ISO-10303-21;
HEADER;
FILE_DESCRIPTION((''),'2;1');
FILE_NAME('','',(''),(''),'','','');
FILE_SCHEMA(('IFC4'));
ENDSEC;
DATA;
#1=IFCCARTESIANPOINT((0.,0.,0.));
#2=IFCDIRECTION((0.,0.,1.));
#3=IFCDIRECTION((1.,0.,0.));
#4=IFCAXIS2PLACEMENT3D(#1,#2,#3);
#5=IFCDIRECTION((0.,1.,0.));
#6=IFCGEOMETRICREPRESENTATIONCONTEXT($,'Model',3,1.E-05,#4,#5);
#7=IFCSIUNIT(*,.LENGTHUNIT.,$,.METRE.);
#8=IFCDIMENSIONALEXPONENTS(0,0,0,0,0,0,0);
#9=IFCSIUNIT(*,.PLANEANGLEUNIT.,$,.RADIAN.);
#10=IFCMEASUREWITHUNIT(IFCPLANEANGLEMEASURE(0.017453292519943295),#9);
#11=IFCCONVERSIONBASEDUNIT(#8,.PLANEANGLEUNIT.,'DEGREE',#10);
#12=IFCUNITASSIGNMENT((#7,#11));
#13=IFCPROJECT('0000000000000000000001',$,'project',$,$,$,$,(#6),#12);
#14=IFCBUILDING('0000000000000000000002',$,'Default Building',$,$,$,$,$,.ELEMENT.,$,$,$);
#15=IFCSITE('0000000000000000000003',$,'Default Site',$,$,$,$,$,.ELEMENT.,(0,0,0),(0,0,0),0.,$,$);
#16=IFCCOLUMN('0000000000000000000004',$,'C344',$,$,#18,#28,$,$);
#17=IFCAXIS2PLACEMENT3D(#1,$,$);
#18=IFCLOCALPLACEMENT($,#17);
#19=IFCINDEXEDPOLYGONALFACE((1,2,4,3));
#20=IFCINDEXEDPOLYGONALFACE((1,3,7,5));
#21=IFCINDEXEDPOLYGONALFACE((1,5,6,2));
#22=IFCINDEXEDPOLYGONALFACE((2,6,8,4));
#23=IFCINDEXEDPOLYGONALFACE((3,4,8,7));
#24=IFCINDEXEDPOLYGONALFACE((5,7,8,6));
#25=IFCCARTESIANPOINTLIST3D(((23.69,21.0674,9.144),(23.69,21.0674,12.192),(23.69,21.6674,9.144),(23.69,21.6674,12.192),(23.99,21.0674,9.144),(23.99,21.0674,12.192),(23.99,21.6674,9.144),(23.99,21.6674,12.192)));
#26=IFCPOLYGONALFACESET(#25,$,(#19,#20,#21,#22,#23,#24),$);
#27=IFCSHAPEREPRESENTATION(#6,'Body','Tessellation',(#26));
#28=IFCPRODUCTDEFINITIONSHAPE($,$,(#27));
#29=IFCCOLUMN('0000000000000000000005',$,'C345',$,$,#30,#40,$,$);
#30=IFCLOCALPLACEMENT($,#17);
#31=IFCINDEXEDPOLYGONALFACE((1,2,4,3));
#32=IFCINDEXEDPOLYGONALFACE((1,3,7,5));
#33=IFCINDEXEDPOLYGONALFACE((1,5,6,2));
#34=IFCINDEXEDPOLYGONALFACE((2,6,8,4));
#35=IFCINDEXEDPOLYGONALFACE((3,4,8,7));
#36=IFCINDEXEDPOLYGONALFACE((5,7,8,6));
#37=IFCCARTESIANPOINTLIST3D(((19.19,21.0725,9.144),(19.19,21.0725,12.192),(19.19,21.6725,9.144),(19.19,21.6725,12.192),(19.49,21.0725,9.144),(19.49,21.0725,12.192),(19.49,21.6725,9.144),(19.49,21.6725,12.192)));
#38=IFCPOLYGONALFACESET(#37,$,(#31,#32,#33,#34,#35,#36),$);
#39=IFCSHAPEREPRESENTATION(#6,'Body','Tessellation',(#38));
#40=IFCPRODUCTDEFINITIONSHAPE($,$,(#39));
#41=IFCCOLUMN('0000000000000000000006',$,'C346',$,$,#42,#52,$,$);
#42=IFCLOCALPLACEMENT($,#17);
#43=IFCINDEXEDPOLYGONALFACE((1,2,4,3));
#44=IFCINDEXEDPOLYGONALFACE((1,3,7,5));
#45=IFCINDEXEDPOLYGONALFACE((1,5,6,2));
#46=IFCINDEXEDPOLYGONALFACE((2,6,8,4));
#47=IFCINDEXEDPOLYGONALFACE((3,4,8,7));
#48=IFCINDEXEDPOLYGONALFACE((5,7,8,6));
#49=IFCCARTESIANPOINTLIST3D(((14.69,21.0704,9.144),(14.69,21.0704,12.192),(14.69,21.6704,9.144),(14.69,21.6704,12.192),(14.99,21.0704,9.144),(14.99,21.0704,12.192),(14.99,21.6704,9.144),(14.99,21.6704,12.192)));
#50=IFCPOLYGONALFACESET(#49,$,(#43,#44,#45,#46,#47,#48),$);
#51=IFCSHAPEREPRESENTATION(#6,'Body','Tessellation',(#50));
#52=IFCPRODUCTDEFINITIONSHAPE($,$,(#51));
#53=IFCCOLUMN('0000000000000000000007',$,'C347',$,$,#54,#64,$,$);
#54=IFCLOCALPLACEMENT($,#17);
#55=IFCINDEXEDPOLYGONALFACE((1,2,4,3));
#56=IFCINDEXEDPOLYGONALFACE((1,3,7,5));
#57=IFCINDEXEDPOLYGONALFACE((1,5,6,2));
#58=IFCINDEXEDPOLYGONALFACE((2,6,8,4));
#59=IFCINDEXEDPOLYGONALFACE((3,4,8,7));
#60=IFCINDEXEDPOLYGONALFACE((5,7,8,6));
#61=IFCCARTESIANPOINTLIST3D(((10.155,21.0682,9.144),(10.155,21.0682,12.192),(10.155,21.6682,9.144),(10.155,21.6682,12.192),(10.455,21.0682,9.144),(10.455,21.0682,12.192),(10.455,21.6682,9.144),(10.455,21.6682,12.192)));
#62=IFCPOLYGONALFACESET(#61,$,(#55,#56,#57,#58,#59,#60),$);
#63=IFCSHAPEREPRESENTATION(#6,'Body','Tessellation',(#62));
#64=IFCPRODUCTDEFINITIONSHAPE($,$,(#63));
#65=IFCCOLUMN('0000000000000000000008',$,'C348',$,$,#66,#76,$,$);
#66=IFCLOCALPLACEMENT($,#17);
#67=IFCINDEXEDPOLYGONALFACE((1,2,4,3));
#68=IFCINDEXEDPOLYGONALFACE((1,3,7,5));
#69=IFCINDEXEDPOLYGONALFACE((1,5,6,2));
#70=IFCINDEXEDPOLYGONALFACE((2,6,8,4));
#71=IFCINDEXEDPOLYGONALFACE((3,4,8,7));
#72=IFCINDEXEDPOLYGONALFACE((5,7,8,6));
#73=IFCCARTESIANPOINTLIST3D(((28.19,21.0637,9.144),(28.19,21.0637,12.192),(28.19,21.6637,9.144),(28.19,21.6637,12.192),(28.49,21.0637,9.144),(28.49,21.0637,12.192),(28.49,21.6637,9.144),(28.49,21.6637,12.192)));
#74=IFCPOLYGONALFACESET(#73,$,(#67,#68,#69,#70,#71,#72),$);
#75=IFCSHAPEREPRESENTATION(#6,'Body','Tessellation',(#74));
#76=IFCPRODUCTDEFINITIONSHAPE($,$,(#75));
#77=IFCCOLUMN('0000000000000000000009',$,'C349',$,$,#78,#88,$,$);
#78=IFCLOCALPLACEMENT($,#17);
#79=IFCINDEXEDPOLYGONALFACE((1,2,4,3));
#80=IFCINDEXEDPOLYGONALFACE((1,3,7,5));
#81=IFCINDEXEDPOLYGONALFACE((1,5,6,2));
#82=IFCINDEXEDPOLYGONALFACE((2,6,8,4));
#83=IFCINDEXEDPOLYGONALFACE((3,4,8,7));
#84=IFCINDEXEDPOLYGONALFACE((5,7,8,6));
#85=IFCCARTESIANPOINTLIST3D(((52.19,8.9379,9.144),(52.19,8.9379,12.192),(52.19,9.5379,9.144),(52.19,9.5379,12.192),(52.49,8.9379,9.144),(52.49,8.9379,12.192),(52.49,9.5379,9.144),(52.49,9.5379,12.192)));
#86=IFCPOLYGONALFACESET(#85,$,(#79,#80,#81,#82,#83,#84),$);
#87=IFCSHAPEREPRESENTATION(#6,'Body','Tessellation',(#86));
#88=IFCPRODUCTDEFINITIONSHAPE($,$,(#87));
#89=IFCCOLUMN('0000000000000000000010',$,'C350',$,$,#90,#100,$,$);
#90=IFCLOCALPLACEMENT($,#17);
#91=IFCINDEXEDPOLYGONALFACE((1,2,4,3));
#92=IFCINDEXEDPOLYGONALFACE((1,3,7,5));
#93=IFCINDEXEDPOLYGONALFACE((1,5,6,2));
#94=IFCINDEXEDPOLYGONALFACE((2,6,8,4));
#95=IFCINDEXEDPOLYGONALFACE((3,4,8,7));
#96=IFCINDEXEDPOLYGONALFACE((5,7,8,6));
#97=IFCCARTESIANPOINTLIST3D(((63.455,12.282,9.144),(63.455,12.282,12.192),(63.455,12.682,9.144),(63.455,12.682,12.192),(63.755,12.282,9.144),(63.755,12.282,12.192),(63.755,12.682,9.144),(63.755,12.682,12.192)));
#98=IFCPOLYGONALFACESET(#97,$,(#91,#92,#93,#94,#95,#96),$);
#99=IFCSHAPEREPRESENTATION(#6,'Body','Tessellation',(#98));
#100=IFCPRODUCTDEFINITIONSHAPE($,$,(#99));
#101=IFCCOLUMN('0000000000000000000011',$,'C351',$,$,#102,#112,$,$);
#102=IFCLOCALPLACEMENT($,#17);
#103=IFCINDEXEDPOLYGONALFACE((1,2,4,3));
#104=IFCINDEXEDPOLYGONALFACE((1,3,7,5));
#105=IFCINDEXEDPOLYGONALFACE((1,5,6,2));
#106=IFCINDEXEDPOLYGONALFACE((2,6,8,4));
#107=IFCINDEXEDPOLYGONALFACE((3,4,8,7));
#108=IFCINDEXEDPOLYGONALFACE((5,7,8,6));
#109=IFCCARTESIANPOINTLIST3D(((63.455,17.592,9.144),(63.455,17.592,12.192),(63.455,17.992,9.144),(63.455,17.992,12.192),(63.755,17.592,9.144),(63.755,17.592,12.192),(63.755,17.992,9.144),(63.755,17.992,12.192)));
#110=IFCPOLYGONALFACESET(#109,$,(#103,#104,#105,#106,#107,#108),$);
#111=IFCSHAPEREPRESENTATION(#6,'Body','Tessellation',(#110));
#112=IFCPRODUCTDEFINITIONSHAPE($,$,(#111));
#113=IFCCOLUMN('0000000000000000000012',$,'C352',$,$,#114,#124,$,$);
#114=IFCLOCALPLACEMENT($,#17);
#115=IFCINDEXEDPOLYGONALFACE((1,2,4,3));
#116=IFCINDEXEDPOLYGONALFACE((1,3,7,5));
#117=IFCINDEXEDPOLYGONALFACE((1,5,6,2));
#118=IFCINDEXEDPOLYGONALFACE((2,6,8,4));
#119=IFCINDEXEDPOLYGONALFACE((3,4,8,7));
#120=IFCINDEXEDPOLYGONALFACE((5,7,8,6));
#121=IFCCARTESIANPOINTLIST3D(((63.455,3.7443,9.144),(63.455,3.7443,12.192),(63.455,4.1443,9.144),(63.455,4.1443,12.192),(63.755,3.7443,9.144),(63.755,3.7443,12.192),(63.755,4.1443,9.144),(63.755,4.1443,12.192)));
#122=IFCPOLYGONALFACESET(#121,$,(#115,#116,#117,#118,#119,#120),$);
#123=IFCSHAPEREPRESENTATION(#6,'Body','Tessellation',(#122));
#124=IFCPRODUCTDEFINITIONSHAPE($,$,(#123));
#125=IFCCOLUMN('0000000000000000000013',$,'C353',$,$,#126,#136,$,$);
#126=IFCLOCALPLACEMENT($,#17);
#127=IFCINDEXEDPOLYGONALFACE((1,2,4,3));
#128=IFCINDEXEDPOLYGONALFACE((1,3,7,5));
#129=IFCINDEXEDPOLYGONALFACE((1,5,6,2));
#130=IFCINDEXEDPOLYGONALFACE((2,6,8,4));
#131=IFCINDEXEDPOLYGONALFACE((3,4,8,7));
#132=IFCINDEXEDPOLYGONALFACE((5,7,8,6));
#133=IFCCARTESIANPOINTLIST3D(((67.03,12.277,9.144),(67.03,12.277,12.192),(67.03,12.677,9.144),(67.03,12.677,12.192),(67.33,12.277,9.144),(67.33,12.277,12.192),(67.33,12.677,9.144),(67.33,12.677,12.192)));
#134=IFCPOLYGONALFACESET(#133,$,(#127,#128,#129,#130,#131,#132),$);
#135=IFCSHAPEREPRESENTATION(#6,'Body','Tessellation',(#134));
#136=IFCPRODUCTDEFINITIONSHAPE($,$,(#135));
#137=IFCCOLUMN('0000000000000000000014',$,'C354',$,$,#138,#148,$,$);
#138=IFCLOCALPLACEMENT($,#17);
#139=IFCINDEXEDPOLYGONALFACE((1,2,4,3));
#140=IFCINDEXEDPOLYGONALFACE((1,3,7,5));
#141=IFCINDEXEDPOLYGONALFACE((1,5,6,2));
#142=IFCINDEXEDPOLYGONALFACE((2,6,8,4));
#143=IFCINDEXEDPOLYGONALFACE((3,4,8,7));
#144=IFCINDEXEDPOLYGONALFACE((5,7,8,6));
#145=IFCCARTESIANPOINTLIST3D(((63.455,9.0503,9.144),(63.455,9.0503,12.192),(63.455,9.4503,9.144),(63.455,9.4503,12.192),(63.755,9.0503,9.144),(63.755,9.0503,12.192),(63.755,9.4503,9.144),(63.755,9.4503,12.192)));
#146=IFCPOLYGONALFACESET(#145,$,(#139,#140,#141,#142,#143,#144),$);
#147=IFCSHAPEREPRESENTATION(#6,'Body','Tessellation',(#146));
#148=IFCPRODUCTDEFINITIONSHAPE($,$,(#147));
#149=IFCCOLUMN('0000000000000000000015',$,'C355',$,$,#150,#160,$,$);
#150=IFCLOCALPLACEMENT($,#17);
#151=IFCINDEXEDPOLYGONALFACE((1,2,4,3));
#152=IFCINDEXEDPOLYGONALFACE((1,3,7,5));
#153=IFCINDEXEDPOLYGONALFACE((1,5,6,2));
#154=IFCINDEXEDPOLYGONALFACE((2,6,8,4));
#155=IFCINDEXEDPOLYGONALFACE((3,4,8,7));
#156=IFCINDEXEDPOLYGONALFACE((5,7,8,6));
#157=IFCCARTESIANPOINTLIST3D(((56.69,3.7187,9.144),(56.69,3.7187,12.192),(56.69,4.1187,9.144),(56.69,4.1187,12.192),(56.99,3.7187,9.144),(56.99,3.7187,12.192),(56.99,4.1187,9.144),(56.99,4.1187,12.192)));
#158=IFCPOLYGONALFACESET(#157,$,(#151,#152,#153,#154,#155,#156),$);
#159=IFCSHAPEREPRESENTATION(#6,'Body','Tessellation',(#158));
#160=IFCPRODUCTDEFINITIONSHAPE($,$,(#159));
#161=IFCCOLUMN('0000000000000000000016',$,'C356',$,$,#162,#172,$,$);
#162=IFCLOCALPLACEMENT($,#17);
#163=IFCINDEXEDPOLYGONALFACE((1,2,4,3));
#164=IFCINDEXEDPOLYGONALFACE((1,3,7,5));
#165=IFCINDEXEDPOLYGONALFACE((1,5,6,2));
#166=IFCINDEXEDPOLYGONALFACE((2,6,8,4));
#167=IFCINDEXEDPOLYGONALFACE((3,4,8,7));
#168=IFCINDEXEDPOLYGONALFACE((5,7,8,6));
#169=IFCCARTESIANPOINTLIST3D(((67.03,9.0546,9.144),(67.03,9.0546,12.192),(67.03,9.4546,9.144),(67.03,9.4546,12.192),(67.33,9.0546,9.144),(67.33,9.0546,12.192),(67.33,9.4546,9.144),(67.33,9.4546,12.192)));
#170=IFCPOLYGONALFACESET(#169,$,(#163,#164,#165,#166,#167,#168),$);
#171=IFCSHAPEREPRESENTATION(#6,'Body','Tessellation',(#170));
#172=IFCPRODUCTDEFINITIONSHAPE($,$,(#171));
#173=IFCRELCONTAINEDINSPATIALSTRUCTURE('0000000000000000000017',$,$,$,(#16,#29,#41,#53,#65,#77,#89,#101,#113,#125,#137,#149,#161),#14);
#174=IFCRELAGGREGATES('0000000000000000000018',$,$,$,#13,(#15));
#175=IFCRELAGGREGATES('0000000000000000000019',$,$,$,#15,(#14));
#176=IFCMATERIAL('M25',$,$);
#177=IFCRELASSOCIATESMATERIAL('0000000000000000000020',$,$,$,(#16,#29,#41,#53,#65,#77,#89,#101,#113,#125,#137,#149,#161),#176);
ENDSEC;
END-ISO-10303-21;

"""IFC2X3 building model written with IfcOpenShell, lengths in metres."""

from ifc_helpers import new_model, entity, si_unit, converted_unit, direction, frame, frame_2d, origin_with_axes, place, context, project, spatial, rectangle, extrude, material, element, save


model = new_model("IFC2X3")

# Units and contexts
model_context = context("Model", 3, precision=1e-05, world=origin_with_axes(), true_north=direction((0.0, 1.0, 0.0)))
ifc_project = project(units=[si_unit("LENGTHUNIT", "METRE"), converted_unit("PLANEANGLEUNIT", "DEGREE", entity("IfcPlaneAngleMeasure", 0.017453292519943295), si_unit("PLANEANGLEUNIT", "RADIAN"), dimensions=[0, 0, 0, 0, 0, 0, 0])], contexts=[model_context])

# Site, building
site = spatial("IfcSite", under=ifc_project, Name="Default Site", CompositionType="ELEMENT", RefLatitude=(0, 0, 0), RefLongitude=(0, 0, 0), RefElevation=0.0)
building = spatial("IfcBuilding", under=site, Name="Default Building", CompositionType="ELEMENT")

# Columns
ifc_material = material(Name="M25")
placement = place(None, origin_with_axes())
element("IfcColumn", 1, at=placement, inside=building, material=ifc_material, Name="C344", context=model_context, shape_type="SweptSolid", body=[
    extrude(rectangle(XDim=0.3, YDim=0.6, at=frame_2d((0.0, 0.0), x_axis=(1.0, 0.0, 0.0))), frame((23.84, 21.3674, 9.144), z_axis=(0.0, 0.0, 1.0), x_axis=(1.0, 0.0, 0.0)), (0.0, 0.0, 1.0), 3.048),
])
element("IfcColumn", 2, at=placement, inside=building, material=ifc_material, Name="C345", context=model_context, shape_type="SweptSolid", body=[
    extrude(rectangle(XDim=0.3, YDim=0.6, at=frame_2d((0.0, 0.0), x_axis=(1.0, 0.0, 0.0))), frame((19.34, 21.3725, 9.144), z_axis=(0.0, 0.0, 1.0), x_axis=(1.0, 0.0, 0.0)), (0.0, 0.0, 1.0), 3.048),
])
element("IfcColumn", 3, at=placement, inside=building, material=ifc_material, Name="C346", context=model_context, shape_type="SweptSolid", body=[
    extrude(rectangle(XDim=0.3, YDim=0.6, at=frame_2d((0.0, 0.0), x_axis=(1.0, 0.0, 0.0))), frame((14.84, 21.3704, 9.144), z_axis=(0.0, 0.0, 1.0), x_axis=(1.0, 0.0, 0.0)), (0.0, 0.0, 1.0), 3.048),
])
element("IfcColumn", 4, at=placement, inside=building, material=ifc_material, Name="C347", context=model_context, shape_type="SweptSolid", body=[
    extrude(rectangle(XDim=0.3, YDim=0.6, at=frame_2d((0.0, 0.0), x_axis=(1.0, 0.0, 0.0))), frame((10.305, 21.3682, 9.144), z_axis=(0.0, 0.0, 1.0), x_axis=(1.0, 0.0, 0.0)), (0.0, 0.0, 1.0), 3.048),
])
element("IfcColumn", 5, at=placement, inside=building, material=ifc_material, Name="C348", context=model_context, shape_type="SweptSolid", body=[
    extrude(rectangle(XDim=0.3, YDim=0.6, at=frame_2d((0.0, 0.0), x_axis=(1.0, 0.0, 0.0))), frame((28.34, 21.3637, 9.144), z_axis=(0.0, 0.0, 1.0), x_axis=(1.0, 0.0, 0.0)), (0.0, 0.0, 1.0), 3.048),
])
element("IfcColumn", 6, at=placement, inside=building, material=ifc_material, Name="C349", context=model_context, shape_type="SweptSolid", body=[
    extrude(rectangle(XDim=0.3, YDim=0.6, at=frame_2d((0.0, 0.0), x_axis=(1.0, 0.0, 0.0))), frame((52.34, 9.2379, 9.144), z_axis=(0.0, 0.0, 1.0), x_axis=(1.0, 0.0, 0.0)), (0.0, 0.0, 1.0), 3.048),
])
element("IfcColumn", 7, at=placement, inside=building, material=ifc_material, Name="C350", context=model_context, shape_type="SweptSolid", body=[
    extrude(rectangle(XDim=0.3, YDim=0.4, at=frame_2d((0.0, 0.0), x_axis=(1.0, 0.0, 0.0))), frame((63.605, 12.482, 9.144), z_axis=(0.0, 0.0, 1.0), x_axis=(1.0, 0.0, 0.0)), (0.0, 0.0, 1.0), 3.048),
])
element("IfcColumn", 8, at=placement, inside=building, material=ifc_material, Name="C351", context=model_context, shape_type="SweptSolid", body=[
    extrude(rectangle(XDim=0.3, YDim=0.4, at=frame_2d((0.0, 0.0), x_axis=(1.0, 0.0, 0.0))), frame((63.605, 17.792, 9.144), z_axis=(0.0, 0.0, 1.0), x_axis=(1.0, 0.0, 0.0)), (0.0, 0.0, 1.0), 3.048),
])
element("IfcColumn", 9, at=placement, inside=building, material=ifc_material, Name="C352", context=model_context, shape_type="SweptSolid", body=[
    extrude(rectangle(XDim=0.3, YDim=0.4, at=frame_2d((0.0, 0.0), x_axis=(1.0, 0.0, 0.0))), frame((63.605, 3.9443, 9.144), z_axis=(0.0, 0.0, 1.0), x_axis=(1.0, 0.0, 0.0)), (0.0, 0.0, 1.0), 3.048),
])
element("IfcColumn", 10, at=placement, inside=building, material=ifc_material, Name="C353", context=model_context, shape_type="SweptSolid", body=[
    extrude(rectangle(XDim=0.3, YDim=0.4, at=frame_2d((0.0, 0.0), x_axis=(1.0, 0.0, 0.0))), frame((67.18, 12.477, 9.144), z_axis=(0.0, 0.0, 1.0), x_axis=(1.0, 0.0, 0.0)), (0.0, 0.0, 1.0), 3.048),
])
element("IfcColumn", 11, at=placement, inside=building, material=ifc_material, Name="C354", context=model_context, shape_type="SweptSolid", body=[
    extrude(rectangle(XDim=0.3, YDim=0.4, at=frame_2d((0.0, 0.0), x_axis=(1.0, 0.0, 0.0))), frame((63.605, 9.2503, 9.144), z_axis=(0.0, 0.0, 1.0), x_axis=(1.0, 0.0, 0.0)), (0.0, 0.0, 1.0), 3.048),
])
element("IfcColumn", 12, at=placement, inside=building, material=ifc_material, Name="C355", context=model_context, shape_type="SweptSolid", body=[
    extrude(rectangle(XDim=0.3, YDim=0.4, at=frame_2d((0.0, 0.0), x_axis=(1.0, 0.0, 0.0))), frame((56.84, 3.9187, 9.144), z_axis=(0.0, 0.0, 1.0), x_axis=(1.0, 0.0, 0.0)), (0.0, 0.0, 1.0), 3.048),
])
element("IfcColumn", 13, at=placement, inside=building, material=ifc_material, Name="C356", context=model_context, shape_type="SweptSolid", body=[
    extrude(rectangle(XDim=0.3, YDim=0.4, at=frame_2d((0.0, 0.0), x_axis=(1.0, 0.0, 0.0))), frame((67.18, 9.2546, 9.144), z_axis=(0.0, 0.0, 1.0), x_axis=(1.0, 0.0, 0.0)), (0.0, 0.0, 1.0), 3.048),
])

save(model, "model.ifc")
